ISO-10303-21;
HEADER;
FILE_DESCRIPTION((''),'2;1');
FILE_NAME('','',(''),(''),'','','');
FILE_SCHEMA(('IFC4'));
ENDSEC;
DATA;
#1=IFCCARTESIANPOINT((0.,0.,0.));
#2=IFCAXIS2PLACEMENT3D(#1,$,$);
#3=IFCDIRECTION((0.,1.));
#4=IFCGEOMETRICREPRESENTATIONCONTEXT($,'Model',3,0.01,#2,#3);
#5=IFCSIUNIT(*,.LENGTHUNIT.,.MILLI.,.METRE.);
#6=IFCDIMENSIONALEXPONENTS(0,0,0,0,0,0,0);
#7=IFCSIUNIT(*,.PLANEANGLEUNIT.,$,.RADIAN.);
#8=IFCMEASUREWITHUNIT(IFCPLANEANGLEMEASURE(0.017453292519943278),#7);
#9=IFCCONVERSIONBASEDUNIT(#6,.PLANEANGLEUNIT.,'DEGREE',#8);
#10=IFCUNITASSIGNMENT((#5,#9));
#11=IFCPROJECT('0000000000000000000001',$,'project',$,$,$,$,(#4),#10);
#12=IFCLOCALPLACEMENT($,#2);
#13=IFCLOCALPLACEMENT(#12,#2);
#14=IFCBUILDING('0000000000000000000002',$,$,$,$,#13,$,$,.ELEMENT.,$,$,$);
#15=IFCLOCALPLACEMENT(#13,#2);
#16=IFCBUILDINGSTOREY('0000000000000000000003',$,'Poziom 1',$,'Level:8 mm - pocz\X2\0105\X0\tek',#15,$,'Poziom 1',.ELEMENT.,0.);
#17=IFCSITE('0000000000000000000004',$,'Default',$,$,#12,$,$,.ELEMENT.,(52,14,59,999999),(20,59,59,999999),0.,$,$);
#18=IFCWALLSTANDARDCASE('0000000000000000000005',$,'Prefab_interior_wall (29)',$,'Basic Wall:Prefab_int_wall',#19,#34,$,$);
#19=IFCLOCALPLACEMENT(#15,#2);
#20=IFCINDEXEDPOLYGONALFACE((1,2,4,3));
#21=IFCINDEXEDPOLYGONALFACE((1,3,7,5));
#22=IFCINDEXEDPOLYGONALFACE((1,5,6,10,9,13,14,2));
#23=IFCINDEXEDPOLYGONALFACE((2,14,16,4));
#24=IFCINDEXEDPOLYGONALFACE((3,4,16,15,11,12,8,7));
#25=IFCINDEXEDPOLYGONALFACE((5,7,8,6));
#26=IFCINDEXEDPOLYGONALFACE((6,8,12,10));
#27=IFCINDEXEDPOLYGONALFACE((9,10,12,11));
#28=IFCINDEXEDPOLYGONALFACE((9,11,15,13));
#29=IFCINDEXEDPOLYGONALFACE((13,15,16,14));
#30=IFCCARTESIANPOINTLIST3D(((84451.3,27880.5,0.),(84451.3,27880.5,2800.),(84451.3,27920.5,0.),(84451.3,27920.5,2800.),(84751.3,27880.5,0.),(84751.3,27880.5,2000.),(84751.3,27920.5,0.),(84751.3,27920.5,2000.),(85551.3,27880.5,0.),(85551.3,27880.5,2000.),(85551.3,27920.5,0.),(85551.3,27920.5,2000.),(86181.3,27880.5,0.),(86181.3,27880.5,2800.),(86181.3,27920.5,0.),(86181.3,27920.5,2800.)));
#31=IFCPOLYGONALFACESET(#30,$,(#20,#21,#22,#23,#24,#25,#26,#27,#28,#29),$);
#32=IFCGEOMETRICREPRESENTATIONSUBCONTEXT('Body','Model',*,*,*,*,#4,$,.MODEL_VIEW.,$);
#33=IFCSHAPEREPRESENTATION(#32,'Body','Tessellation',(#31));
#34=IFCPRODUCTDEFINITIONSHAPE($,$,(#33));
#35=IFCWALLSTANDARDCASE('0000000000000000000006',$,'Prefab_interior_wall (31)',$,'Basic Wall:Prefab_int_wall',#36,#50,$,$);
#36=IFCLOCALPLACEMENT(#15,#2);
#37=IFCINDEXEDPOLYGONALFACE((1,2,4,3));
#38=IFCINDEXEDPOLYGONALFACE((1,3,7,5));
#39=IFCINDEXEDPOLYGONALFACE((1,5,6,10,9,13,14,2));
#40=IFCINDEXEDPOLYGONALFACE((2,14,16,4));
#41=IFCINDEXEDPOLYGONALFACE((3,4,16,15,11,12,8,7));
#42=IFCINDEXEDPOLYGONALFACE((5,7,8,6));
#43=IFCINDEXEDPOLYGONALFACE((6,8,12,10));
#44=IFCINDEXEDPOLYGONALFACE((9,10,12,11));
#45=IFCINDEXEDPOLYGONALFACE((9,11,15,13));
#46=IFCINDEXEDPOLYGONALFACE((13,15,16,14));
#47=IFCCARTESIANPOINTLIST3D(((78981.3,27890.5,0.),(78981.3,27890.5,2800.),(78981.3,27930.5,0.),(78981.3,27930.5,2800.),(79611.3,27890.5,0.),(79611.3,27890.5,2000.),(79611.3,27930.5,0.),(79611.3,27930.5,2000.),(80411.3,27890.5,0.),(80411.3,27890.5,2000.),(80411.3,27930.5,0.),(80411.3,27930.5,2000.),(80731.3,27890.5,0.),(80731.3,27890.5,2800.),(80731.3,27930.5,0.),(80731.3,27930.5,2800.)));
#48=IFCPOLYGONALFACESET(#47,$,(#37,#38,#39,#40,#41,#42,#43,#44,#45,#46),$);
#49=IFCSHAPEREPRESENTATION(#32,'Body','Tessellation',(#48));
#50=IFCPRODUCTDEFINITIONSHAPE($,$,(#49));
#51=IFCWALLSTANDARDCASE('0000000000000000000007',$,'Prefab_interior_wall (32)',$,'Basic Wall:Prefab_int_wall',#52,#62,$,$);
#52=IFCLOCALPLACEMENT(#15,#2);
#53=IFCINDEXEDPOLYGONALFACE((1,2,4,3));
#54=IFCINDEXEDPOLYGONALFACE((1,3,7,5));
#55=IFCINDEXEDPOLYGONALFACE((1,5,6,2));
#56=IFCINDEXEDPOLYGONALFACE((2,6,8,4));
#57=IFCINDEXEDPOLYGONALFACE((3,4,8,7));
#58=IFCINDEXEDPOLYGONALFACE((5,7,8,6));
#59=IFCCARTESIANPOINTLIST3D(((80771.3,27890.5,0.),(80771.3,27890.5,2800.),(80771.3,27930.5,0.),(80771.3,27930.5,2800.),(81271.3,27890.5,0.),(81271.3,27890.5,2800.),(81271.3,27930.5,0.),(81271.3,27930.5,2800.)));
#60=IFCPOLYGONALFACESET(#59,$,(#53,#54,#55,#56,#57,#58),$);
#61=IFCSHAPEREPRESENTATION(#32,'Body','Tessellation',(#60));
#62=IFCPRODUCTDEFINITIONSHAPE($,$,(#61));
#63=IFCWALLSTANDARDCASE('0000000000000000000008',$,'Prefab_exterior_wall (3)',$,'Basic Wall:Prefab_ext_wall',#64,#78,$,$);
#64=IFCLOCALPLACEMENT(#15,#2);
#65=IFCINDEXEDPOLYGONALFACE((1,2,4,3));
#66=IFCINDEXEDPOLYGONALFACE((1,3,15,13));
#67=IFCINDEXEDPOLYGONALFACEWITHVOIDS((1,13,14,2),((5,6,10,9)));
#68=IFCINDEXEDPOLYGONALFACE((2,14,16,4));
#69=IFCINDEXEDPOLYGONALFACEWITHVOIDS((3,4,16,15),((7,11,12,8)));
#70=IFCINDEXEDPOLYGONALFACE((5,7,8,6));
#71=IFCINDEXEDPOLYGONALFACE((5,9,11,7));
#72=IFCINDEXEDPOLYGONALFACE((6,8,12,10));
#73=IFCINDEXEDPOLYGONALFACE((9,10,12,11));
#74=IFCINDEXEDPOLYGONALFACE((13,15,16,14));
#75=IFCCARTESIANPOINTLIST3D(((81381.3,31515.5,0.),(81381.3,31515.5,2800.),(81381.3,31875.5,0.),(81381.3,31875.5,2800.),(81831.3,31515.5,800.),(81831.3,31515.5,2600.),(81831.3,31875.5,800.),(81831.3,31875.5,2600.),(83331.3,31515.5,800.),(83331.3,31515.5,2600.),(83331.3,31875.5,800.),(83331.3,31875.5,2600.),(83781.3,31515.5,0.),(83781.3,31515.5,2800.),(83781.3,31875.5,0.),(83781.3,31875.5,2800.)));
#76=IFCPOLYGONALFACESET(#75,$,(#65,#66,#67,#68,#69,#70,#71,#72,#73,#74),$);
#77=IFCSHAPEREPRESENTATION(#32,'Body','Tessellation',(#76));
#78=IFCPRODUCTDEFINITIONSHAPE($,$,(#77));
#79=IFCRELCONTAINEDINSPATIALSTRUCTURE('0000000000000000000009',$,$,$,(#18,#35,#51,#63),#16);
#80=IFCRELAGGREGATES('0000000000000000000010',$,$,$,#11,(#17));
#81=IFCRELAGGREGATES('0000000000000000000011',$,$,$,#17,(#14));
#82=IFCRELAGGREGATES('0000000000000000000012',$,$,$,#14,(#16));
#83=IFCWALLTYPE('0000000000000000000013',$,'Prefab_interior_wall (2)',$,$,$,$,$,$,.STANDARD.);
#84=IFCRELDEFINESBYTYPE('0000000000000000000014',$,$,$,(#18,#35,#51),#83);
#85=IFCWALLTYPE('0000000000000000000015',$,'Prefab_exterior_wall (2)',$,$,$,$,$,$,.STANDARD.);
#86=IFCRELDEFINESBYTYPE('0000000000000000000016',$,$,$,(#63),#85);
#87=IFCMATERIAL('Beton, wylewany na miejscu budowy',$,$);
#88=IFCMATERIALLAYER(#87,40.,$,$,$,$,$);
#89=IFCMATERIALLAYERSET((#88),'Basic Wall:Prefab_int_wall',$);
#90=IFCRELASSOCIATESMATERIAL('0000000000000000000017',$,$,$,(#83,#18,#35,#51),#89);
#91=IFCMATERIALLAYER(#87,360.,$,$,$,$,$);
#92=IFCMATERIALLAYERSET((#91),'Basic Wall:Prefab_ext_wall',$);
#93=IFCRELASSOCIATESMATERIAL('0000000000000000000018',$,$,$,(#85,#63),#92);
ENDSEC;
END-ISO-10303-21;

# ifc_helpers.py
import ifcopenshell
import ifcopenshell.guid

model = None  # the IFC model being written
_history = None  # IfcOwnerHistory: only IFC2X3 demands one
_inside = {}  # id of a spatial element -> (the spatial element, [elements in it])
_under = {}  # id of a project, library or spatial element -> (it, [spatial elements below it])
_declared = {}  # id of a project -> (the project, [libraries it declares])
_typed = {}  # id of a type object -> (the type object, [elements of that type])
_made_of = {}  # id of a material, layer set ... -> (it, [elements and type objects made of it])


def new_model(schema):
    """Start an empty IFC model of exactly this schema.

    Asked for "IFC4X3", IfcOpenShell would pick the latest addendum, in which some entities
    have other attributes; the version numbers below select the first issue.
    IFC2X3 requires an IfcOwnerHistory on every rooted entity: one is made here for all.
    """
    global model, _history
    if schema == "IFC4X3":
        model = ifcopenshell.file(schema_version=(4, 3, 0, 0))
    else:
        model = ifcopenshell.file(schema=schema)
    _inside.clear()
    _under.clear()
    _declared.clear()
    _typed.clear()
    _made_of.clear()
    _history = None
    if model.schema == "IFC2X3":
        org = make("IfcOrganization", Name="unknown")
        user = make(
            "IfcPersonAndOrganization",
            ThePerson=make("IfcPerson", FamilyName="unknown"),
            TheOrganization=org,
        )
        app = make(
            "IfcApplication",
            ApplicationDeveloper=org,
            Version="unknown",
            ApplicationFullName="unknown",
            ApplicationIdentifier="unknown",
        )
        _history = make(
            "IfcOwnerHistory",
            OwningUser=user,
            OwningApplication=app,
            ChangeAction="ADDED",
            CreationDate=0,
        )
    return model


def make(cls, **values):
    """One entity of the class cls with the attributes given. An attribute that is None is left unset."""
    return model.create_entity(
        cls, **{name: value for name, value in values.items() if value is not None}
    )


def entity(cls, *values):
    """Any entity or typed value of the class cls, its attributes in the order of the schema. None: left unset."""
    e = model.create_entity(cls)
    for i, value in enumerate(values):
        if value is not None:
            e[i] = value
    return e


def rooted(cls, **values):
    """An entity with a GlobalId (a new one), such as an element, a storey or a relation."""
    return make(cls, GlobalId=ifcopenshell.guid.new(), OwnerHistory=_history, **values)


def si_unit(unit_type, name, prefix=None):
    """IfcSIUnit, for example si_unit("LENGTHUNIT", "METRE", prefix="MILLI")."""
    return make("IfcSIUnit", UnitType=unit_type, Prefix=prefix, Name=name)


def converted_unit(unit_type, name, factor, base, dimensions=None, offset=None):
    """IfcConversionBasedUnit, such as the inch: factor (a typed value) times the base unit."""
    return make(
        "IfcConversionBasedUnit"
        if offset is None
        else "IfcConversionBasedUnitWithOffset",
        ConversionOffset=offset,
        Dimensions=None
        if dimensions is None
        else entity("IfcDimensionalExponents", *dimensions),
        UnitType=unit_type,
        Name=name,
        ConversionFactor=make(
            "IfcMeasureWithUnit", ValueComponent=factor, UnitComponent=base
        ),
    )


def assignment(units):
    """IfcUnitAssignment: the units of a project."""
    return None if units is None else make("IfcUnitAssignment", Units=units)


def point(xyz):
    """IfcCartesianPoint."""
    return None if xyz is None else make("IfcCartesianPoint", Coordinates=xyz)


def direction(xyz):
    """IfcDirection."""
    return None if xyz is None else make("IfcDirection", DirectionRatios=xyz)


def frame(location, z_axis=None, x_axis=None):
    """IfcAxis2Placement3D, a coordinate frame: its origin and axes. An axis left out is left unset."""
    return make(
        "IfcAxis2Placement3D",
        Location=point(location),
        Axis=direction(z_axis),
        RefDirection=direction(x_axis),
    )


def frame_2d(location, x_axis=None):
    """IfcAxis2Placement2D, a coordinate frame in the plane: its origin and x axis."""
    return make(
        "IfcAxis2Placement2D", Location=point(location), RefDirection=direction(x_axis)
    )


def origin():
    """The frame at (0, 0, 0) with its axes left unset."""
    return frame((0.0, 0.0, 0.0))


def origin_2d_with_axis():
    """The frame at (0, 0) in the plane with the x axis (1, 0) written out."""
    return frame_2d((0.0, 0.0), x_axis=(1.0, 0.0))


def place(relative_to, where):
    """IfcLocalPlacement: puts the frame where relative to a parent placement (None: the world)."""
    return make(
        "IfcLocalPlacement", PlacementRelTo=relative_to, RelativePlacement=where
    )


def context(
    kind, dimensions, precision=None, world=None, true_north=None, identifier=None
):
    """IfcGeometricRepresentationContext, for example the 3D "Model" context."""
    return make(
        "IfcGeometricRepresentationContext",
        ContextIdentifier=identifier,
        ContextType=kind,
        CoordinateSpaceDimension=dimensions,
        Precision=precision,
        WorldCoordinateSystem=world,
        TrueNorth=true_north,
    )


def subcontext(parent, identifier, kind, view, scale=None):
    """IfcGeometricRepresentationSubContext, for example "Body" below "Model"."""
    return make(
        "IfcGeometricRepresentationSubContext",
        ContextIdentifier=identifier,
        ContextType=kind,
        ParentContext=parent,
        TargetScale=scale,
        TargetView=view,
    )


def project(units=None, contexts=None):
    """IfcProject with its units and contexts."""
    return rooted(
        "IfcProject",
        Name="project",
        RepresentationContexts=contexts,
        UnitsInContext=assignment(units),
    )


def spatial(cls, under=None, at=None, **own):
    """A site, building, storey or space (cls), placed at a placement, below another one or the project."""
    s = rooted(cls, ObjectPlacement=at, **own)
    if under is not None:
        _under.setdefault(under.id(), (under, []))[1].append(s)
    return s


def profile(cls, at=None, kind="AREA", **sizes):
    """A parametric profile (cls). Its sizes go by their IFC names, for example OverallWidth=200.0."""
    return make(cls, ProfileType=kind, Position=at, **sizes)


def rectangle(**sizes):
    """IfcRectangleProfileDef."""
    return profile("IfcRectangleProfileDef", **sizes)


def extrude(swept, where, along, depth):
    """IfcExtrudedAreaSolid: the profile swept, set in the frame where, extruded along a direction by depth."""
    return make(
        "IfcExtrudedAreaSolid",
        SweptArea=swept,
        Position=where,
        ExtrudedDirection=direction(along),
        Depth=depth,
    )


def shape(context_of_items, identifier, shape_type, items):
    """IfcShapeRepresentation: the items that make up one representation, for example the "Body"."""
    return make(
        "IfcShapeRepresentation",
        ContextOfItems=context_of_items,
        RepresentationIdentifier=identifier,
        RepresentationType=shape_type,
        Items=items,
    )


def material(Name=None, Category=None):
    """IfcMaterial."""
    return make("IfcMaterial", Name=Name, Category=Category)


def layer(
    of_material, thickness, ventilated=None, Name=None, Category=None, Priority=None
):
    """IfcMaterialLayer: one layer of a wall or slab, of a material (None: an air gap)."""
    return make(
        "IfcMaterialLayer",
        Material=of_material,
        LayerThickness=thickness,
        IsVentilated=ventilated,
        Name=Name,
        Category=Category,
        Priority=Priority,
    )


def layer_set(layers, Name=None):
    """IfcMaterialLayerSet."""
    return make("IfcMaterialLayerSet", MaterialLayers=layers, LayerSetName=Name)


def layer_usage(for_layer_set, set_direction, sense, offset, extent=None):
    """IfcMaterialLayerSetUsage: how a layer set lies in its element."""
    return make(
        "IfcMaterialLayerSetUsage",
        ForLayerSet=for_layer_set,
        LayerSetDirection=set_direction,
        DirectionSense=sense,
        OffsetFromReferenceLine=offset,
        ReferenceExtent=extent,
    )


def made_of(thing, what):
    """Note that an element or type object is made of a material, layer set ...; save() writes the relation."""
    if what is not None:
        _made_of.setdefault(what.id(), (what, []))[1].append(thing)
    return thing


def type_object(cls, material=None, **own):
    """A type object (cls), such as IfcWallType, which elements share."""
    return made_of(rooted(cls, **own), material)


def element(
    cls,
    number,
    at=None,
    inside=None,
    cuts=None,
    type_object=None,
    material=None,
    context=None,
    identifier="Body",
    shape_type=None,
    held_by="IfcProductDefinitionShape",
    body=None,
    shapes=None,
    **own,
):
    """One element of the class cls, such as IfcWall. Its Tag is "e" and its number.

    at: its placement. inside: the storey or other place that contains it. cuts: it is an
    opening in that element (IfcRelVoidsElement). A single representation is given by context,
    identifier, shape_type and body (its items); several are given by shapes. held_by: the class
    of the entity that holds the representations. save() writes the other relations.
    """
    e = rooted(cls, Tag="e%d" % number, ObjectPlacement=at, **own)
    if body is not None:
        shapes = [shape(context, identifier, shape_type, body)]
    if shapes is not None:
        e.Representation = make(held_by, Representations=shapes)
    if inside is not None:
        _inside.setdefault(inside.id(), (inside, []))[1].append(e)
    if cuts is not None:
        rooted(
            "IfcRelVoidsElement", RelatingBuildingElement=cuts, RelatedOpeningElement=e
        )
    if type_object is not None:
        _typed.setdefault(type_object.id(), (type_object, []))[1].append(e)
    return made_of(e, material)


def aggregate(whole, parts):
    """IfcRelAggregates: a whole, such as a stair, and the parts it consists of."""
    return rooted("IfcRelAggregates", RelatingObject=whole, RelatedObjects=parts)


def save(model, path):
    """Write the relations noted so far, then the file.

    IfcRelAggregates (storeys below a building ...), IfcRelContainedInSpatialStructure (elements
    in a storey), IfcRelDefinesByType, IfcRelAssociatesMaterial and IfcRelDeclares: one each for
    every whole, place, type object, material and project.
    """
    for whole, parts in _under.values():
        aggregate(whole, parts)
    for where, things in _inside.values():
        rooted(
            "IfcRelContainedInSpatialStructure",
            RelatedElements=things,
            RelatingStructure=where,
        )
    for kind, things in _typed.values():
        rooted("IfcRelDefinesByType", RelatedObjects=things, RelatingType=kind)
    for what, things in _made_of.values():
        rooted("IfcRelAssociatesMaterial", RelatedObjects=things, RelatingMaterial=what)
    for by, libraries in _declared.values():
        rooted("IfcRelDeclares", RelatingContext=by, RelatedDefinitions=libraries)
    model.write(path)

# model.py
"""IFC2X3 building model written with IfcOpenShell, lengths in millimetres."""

from ifc_helpers import new_model, entity, si_unit, converted_unit, direction, frame, frame_2d, origin, origin_2d_with_axis, place, context, subcontext, project, spatial, rectangle, extrude, material, layer, layer_set, layer_usage, type_object, element, save


model = new_model("IFC2X3")

# Units and contexts
model_context = context("Model", 3, precision=0.01, world=origin(), true_north=direction((0.0, 1.0)))
body_context = subcontext(model_context, "Body", "Model", "MODEL_VIEW")
ifc_project = project(units=[si_unit("LENGTHUNIT", "METRE", prefix="MILLI"), converted_unit("PLANEANGLEUNIT", "DEGREE", entity("IfcPlaneAngleMeasure", 0.017453292519943278), si_unit("PLANEANGLEUNIT", "RADIAN"), dimensions=[0, 0, 0, 0, 0, 0, 0])], contexts=[model_context])

# Site, building, storey
site_placement = place(None, origin())
site = spatial("IfcSite", under=ifc_project, at=site_placement, Name="Default", CompositionType="ELEMENT", RefLatitude=(52, 14, 59, 999999), RefLongitude=(20, 59, 59, 999999), RefElevation=0.0)
building_placement = place(site_placement, origin())
building = spatial("IfcBuilding", under=site, at=building_placement, CompositionType="ELEMENT")
storey_placement = place(building_placement, origin())
storey = spatial("IfcBuildingStorey", under=building, at=storey_placement, Name="Poziom 1", ObjectType="Level:8 mm - początek", LongName="Poziom 1", CompositionType="ELEMENT", Elevation=0.0)

# Shared definitions
ifc_material = material(Name="Beton, wylewany na miejscu budowy")
ifc_layer_1 = layer(ifc_material, 40.0)
ifc_layer_set_1 = layer_set([ifc_layer_1], Name="Basic Wall:Prefab_int_wall")
wall_type_1 = type_object("IfcWallType", Name="Prefab_interior_wall (2)", PredefinedType="STANDARD", material=ifc_layer_set_1)

# Walls, openings
ifc_layer_usage_1 = layer_usage(ifc_layer_set_1, "AXIS2", "NEGATIVE", 20.0)
wall_1_placement = place(storey_placement, frame((84451.3, 27900.5, 0.0)))
wall_1 = element("IfcWallStandardCase", 1, at=wall_1_placement, inside=storey, type_object=wall_type_1, material=ifc_layer_usage_1, Name="Prefab_interior_wall (29)", ObjectType="Basic Wall:Prefab_int_wall", context=body_context, shape_type="SweptSolid", body=[
    extrude(rectangle(XDim=1730.0, YDim=40.0, at=frame_2d((865.0, 0.0), x_axis=(-1.0, 0.0))), origin(), (0.0, 0.0, 1.0), 2800.0),
])
opening_1_placement = place(wall_1_placement, origin())
element("IfcOpeningElement", 2, at=opening_1_placement, cuts=wall_1, ObjectType="Opening", context=body_context, shape_type="SweptSolid", body=[
    extrude(rectangle(XDim=2000.0, YDim=800.0, at=frame_2d((0.0, 0.0), x_axis=(0.0, 1.0))), frame((700.0, 20.0, 1000.0), z_axis=(0.0, -1.0, 0.0), x_axis=(1.0, 0.0, 0.0)), (0.0, 0.0, 1.0), 40.0),
])
ifc_layer_usage_2 = layer_usage(ifc_layer_set_1, "AXIS2", "NEGATIVE", 20.0)
wall_2_placement = place(storey_placement, frame((78981.3, 27910.5, 0.0)))
wall_2 = element("IfcWallStandardCase", 3, at=wall_2_placement, inside=storey, type_object=wall_type_1, material=ifc_layer_usage_2, Name="Prefab_interior_wall (31)", ObjectType="Basic Wall:Prefab_int_wall", context=body_context, shape_type="SweptSolid", body=[
    extrude(rectangle(XDim=1750.0, YDim=40.0, at=frame_2d((875.0, 0.0), x_axis=(-1.0, 0.0))), origin(), (0.0, 0.0, 1.0), 2800.0),
])
opening_2_placement = place(wall_2_placement, origin())
element("IfcOpeningElement", 4, at=opening_2_placement, cuts=wall_2, ObjectType="Opening", context=body_context, shape_type="SweptSolid", body=[
    extrude(rectangle(XDim=2000.0, YDim=800.0, at=frame_2d((0.0, 0.0), x_axis=(0.0, 1.0))), frame((1030.0, 20.0, 1000.0), z_axis=(0.0, -1.0, 0.0), x_axis=(1.0, 0.0, 0.0)), (0.0, 0.0, 1.0), 40.0),
])

# Wall
ifc_layer_usage_3 = layer_usage(ifc_layer_set_1, "AXIS2", "NEGATIVE", 20.0)
wall_3_placement = place(storey_placement, frame((80771.3, 27910.5, 0.0)))
element("IfcWallStandardCase", 5, at=wall_3_placement, inside=storey, type_object=wall_type_1, material=ifc_layer_usage_3, Name="Prefab_interior_wall (32)", ObjectType="Basic Wall:Prefab_int_wall", context=body_context, shape_type="SweptSolid", body=[
    extrude(rectangle(XDim=500.0, YDim=40.0, at=frame_2d((250.0, 0.0), x_axis=(-1.0, 0.0))), origin(), (0.0, 0.0, 1.0), 2800.0),
])

# Wall, opening
ifc_layer_2 = layer(ifc_material, 360.0)
ifc_layer_set_2 = layer_set([ifc_layer_2], Name="Basic Wall:Prefab_ext_wall")
ifc_layer_usage_4 = layer_usage(ifc_layer_set_2, "AXIS2", "NEGATIVE", 180.0)
wall_type_2 = type_object("IfcWallType", Name="Prefab_exterior_wall (2)", PredefinedType="STANDARD", material=ifc_layer_set_2)
wall_4_placement = place(storey_placement, frame((81381.3, 31695.5, 0.0)))
wall_4 = element("IfcWallStandardCase", 6, at=wall_4_placement, inside=storey, type_object=wall_type_2, material=ifc_layer_usage_4, Name="Prefab_exterior_wall (3)", ObjectType="Basic Wall:Prefab_ext_wall", context=body_context, shape_type="SweptSolid", body=[
    extrude(rectangle(XDim=2400.0, YDim=360.0, at=frame_2d((1200.0, 0.0), x_axis=(-1.0, 0.0))), origin(), (0.0, 0.0, 1.0), 2800.0),
])
opening_3_placement = place(wall_4_placement, origin())
element("IfcOpeningElement", 7, at=opening_3_placement, cuts=wall_4, ObjectType="Opening", context=body_context, shape_type="SweptSolid", body=[
    extrude(rectangle(XDim=1800.0, YDim=1500.0, at=origin_2d_with_axis()), frame((1200.0, 180.0, 1700.0), z_axis=(0.0, -1.0, 0.0), x_axis=(0.0, 0.0, 1.0)), (0.0, 0.0, 1.0), 360.0),
])

save(model, "model.ifc")
